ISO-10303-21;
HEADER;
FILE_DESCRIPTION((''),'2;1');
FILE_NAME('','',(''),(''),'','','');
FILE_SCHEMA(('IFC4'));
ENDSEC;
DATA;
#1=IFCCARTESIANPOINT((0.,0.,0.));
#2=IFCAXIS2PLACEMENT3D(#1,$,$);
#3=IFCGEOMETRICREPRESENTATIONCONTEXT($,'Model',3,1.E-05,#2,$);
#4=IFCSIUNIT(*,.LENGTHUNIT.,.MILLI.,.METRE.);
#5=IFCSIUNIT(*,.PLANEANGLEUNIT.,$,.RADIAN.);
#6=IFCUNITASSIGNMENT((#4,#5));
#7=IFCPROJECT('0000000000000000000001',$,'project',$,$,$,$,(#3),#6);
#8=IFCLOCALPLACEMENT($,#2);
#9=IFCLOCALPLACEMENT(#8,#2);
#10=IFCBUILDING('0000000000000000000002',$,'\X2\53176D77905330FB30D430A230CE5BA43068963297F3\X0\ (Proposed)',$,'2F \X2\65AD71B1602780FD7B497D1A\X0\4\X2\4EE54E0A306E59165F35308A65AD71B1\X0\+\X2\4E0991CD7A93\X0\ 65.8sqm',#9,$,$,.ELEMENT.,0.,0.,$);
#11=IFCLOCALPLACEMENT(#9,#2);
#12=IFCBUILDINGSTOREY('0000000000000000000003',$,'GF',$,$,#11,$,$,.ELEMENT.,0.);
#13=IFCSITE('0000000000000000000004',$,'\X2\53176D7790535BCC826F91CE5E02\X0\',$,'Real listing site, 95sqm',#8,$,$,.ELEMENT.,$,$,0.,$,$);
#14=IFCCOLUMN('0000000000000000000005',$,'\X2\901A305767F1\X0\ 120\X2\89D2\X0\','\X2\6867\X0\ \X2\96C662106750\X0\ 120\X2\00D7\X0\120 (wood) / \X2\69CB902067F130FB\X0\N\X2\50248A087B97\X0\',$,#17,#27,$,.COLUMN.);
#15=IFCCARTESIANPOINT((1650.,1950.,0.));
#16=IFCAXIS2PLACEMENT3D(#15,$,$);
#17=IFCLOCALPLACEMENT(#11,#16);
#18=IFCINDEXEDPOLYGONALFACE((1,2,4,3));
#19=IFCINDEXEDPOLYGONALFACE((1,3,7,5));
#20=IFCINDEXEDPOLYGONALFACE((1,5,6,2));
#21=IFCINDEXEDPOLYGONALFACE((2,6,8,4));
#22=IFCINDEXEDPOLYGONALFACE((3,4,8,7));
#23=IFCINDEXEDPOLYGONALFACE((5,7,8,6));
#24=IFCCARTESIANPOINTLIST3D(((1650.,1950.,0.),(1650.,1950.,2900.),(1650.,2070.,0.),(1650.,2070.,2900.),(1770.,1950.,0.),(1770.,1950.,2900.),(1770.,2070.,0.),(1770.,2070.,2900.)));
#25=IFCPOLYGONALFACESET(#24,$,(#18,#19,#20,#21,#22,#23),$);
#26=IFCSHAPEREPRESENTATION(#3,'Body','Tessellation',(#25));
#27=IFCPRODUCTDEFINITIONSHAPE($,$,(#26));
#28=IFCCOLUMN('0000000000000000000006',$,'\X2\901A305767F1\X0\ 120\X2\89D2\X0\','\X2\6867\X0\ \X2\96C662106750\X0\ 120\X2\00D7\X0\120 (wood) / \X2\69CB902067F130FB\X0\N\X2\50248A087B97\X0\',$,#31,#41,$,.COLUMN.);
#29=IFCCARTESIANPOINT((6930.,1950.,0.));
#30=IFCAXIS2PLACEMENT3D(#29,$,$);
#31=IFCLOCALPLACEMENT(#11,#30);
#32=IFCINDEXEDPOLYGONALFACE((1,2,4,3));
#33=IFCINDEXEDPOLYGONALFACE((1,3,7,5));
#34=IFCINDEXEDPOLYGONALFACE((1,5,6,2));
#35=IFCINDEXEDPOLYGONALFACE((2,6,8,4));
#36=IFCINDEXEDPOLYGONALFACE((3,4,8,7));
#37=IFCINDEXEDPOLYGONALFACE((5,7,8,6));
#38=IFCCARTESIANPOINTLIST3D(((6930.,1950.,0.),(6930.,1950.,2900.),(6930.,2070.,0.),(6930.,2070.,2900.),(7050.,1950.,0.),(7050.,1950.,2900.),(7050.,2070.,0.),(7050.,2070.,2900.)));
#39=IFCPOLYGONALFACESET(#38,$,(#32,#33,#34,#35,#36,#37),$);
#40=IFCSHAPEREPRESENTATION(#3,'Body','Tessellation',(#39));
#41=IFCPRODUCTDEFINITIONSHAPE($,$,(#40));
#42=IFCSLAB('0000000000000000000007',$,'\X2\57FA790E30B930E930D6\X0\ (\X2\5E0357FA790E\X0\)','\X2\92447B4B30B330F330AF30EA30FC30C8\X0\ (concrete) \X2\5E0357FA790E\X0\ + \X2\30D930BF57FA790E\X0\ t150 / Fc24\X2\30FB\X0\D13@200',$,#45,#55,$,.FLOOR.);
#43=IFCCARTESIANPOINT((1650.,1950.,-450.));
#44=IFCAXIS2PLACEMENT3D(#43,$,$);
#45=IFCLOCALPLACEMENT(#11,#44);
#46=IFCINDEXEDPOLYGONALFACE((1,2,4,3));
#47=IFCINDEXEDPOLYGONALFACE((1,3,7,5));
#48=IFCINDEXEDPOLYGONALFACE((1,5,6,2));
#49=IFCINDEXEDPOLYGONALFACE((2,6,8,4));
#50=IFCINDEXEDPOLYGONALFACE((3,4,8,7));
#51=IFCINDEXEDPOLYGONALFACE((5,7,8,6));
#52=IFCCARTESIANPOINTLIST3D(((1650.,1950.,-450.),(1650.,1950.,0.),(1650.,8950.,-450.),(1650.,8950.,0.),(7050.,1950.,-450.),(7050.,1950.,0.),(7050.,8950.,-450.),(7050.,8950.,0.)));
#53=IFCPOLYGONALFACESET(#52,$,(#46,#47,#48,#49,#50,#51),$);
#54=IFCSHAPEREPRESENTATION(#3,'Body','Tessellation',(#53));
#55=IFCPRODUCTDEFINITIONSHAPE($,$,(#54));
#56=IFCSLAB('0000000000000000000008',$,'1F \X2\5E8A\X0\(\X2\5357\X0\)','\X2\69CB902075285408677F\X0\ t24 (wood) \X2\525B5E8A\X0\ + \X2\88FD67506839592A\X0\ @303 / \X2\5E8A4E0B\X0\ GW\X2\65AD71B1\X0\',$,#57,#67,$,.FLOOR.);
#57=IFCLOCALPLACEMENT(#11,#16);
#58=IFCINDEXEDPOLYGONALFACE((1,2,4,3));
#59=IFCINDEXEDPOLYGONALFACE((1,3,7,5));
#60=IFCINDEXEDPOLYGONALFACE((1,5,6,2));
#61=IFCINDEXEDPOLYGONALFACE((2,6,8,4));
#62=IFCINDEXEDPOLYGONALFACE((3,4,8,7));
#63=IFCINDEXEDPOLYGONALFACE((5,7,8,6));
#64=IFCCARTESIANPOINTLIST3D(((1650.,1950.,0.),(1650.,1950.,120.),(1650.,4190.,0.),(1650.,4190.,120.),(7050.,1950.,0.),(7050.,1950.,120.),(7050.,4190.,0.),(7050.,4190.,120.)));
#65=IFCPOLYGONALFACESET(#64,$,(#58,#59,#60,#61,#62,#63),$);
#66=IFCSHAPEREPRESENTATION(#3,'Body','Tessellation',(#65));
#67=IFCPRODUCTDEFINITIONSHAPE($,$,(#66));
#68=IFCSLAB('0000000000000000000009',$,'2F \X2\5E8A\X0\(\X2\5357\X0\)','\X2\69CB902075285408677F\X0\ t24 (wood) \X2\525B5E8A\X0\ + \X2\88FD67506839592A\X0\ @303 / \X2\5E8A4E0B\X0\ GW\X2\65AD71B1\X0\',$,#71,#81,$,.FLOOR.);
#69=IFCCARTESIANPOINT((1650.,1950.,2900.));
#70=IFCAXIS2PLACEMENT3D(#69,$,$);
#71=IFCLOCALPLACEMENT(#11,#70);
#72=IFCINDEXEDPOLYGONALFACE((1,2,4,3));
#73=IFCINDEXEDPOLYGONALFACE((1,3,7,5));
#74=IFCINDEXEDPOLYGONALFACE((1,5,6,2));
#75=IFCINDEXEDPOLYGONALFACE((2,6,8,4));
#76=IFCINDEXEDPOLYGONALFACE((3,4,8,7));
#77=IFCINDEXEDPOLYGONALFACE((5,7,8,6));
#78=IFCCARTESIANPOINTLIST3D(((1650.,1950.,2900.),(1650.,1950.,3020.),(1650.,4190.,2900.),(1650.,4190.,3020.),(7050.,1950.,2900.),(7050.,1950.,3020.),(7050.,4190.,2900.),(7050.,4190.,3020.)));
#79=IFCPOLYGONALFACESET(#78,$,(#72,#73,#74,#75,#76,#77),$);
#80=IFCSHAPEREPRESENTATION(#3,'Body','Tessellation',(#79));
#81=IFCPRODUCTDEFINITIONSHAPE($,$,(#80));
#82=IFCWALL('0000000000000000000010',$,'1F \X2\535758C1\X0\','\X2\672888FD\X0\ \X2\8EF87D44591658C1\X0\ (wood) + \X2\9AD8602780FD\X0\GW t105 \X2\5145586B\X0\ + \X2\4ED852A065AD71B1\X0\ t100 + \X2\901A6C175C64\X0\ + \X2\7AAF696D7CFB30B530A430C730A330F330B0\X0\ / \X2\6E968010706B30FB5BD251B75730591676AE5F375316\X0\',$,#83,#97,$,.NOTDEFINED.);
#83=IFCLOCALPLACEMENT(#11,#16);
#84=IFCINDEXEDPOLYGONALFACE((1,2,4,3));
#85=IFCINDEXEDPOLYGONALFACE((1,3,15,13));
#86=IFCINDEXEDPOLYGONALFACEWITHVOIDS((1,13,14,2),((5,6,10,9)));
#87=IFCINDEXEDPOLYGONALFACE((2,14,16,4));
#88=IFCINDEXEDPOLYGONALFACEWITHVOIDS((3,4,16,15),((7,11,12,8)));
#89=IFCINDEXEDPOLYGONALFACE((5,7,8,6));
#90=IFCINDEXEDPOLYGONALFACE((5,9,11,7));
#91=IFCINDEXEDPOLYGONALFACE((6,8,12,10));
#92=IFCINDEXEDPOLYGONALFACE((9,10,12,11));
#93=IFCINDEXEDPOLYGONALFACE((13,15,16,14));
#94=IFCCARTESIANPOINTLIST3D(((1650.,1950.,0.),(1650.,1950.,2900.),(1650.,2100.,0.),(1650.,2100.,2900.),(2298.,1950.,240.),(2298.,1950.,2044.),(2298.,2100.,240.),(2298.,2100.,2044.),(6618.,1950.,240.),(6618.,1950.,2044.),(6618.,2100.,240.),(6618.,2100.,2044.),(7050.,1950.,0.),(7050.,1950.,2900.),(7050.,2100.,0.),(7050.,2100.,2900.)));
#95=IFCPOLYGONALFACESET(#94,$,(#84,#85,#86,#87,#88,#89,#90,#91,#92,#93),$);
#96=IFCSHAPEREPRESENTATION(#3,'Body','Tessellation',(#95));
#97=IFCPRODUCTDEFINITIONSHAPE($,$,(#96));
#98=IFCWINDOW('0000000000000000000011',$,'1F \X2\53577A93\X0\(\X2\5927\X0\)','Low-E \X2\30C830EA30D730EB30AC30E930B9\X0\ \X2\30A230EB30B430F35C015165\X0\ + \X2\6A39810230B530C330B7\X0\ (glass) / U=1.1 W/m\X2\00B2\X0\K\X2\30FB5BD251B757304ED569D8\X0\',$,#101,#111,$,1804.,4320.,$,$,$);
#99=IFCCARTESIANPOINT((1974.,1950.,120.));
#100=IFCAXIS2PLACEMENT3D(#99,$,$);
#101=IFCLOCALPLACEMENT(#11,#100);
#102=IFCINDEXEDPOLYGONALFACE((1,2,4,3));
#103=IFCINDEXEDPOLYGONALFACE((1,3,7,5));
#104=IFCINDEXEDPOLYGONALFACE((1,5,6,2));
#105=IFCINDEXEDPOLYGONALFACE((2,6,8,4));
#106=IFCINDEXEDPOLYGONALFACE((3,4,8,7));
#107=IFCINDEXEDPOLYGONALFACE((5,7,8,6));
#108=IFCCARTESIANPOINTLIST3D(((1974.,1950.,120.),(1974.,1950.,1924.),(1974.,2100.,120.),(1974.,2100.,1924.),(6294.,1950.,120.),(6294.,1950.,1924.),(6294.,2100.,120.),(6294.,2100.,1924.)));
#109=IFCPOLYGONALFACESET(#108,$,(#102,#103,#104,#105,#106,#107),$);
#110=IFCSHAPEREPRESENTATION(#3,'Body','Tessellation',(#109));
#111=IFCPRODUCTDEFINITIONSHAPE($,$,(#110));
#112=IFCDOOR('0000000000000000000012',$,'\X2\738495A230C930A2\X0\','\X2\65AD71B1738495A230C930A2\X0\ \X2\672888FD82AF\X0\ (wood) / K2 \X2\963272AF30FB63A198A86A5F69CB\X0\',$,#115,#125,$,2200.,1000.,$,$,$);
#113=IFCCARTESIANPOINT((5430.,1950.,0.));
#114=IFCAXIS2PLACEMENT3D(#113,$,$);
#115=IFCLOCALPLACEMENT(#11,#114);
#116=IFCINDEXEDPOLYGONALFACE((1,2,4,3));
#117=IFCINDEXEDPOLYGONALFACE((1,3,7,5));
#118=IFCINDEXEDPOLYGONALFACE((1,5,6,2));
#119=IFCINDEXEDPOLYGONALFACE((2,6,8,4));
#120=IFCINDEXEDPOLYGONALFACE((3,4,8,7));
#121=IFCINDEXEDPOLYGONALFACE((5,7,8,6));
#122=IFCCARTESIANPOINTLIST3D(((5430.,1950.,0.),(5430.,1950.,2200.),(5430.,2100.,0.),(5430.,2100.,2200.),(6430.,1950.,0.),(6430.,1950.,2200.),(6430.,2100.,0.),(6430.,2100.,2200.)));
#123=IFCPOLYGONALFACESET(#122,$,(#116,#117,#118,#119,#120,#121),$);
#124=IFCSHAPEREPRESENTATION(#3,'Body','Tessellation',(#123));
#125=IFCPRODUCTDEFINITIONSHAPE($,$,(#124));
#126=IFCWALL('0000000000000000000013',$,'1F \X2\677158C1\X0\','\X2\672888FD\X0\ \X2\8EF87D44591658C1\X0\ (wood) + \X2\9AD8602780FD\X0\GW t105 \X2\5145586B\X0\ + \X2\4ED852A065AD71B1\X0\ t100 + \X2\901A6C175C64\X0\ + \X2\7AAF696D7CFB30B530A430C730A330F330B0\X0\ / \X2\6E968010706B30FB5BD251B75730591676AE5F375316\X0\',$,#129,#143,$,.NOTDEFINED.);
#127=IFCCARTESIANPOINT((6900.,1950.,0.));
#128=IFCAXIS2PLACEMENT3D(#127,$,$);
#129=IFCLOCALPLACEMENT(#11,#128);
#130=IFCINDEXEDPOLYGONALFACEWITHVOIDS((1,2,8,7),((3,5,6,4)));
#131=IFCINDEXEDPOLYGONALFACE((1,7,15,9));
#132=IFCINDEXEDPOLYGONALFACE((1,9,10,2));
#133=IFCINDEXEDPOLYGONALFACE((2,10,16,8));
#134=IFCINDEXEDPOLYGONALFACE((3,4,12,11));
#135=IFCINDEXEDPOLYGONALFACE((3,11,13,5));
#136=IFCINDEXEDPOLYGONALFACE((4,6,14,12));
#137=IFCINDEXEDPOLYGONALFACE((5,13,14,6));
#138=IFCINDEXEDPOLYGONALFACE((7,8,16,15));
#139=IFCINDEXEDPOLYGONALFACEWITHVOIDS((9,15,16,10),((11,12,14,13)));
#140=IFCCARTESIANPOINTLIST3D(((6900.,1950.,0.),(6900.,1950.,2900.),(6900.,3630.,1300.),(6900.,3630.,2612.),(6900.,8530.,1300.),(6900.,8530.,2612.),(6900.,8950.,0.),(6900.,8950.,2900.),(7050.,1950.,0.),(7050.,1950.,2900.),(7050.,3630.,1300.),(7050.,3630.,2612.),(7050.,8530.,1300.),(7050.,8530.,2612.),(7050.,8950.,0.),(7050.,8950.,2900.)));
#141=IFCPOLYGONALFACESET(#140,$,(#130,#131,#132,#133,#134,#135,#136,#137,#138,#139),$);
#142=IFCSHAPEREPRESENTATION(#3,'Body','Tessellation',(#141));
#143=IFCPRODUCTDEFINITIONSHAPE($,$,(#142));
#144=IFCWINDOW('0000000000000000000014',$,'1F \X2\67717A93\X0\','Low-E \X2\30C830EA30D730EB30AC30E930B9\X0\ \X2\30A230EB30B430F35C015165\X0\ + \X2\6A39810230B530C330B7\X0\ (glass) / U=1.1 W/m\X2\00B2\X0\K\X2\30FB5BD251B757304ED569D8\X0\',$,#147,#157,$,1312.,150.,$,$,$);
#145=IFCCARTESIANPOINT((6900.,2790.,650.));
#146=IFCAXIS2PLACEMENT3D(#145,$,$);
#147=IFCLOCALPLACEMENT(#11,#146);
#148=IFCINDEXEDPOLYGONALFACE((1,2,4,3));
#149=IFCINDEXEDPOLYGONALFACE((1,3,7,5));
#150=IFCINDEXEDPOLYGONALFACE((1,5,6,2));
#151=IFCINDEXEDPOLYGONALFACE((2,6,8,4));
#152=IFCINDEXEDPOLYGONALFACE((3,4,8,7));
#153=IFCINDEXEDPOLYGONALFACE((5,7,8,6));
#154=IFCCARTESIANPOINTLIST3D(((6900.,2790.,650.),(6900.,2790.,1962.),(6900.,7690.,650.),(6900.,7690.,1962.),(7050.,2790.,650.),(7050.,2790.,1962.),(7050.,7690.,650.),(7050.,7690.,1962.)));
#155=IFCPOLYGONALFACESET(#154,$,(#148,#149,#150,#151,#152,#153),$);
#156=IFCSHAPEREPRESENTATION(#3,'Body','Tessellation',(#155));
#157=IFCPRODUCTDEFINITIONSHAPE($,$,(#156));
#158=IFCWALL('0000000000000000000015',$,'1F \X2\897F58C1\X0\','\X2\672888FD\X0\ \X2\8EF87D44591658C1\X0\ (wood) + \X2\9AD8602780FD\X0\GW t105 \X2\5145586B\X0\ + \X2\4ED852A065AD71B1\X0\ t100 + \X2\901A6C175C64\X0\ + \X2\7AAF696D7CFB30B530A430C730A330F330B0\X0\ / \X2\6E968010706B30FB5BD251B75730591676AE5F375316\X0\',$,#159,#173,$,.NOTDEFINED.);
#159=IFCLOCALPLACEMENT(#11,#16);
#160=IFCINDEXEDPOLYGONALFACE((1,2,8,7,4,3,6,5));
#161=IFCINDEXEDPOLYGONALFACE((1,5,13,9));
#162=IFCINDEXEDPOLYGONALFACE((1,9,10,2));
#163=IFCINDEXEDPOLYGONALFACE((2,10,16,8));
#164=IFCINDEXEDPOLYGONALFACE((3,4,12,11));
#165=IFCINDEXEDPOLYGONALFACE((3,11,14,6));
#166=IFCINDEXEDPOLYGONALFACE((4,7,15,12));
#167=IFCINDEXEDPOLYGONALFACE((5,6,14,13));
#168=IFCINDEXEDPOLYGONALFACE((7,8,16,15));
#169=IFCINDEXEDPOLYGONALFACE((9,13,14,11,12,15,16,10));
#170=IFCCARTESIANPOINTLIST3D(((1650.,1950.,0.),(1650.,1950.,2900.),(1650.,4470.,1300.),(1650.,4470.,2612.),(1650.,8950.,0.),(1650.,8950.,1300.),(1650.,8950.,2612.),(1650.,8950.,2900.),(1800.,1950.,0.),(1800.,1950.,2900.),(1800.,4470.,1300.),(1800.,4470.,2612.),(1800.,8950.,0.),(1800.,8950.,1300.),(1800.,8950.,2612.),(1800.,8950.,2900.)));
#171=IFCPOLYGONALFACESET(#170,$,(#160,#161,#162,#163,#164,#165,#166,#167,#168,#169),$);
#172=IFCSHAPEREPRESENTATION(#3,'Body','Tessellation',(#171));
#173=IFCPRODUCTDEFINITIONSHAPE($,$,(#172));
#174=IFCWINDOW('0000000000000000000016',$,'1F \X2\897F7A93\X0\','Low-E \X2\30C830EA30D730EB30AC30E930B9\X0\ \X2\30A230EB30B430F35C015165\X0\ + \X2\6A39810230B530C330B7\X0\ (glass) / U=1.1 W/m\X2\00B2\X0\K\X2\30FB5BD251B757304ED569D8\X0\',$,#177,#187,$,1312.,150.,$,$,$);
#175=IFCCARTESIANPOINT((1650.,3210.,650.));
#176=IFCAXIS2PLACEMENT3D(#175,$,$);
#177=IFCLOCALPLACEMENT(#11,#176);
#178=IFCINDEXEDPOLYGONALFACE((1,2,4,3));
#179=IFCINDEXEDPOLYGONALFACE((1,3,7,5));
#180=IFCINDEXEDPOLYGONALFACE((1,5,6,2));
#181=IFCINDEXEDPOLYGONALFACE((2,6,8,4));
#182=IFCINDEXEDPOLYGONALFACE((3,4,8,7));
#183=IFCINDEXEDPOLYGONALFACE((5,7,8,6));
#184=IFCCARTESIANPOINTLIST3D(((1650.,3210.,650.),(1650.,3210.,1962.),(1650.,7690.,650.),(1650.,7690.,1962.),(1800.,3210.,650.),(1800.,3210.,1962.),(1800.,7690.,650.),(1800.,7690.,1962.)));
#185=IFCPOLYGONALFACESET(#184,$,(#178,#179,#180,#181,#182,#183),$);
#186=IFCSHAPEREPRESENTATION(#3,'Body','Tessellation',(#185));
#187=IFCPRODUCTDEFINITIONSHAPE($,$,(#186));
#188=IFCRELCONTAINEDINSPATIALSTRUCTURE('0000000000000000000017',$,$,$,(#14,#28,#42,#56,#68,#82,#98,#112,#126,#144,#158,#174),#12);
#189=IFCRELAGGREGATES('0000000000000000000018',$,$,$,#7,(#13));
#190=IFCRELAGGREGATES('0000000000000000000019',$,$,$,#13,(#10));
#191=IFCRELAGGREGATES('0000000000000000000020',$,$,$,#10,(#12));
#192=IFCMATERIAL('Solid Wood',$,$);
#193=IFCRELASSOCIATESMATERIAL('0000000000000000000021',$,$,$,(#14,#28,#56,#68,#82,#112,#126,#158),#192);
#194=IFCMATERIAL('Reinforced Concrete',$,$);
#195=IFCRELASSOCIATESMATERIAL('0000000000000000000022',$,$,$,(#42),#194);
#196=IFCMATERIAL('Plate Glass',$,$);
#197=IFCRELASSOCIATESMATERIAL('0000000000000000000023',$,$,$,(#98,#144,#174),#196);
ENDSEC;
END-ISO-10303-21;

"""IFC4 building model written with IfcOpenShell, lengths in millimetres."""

from ifc_helpers import new_model, si_unit, frame, frame_2d, origin, place, context, project, spatial, rectangle, extrude, material, element, fill, save


model = new_model("IFC4")

# Units and contexts
model_context = context("Model", 3, precision=1e-05, world=origin())
ifc_project = project(units=[si_unit("LENGTHUNIT", "METRE", prefix="MILLI"), si_unit("PLANEANGLEUNIT", "RADIAN")], contexts=[model_context])

# Site, building, storey
site_placement = place(None, origin())
site = spatial("IfcSite", under=ifc_project, at=site_placement, Name="北海道富良野市", ObjectType="Real listing site, 95sqm", CompositionType="ELEMENT", RefElevation=0.0)
building_placement = place(site_placement, origin())
building = spatial("IfcBuilding", under=site, at=building_placement, Name="北海道・ピアノ室と防音 (Proposed)", ObjectType="2F 断熱性能等級4以上の外張り断熱+三重窓 65.8sqm", CompositionType="ELEMENT", ElevationOfRefHeight=0.0, ElevationOfTerrain=0.0)
storey_placement = place(building_placement, origin())
storey = spatial("IfcBuildingStorey", under=building, at=storey_placement, Name="GF", CompositionType="ELEMENT", Elevation=0.0)

# Columns
ifc_material_1 = material(Name="Solid Wood")
column_1_placement = place(storey_placement, frame((1650.0, 1950.0, 0.0)))
element("IfcColumn", 1, at=column_1_placement, inside=storey, material=ifc_material_1, Name="通し柱 120角", Description="桧 集成材 120×120 (wood) / 構造柱・N値計算", PredefinedType="COLUMN", context=model_context, shape_type="SweptSolid", body=[
    extrude(rectangle(XDim=120.0, YDim=120.0, at=frame_2d((60.0, 60.0))), frame((1650.0, 1950.0, 0.0)), (0.0, 0.0, 1.0), 2900.0),
])
column_2_placement = place(storey_placement, frame((6930.0, 1950.0, 0.0)))
element("IfcColumn", 2, at=column_2_placement, inside=storey, material=ifc_material_1, Name="通し柱 120角", Description="桧 集成材 120×120 (wood) / 構造柱・N値計算", PredefinedType="COLUMN", context=model_context, shape_type="SweptSolid", body=[
    extrude(rectangle(XDim=120.0, YDim=120.0, at=frame_2d((60.0, 60.0))), frame((6930.0, 1950.0, 0.0)), (0.0, 0.0, 1.0), 2900.0),
])

# Slabs
ifc_material_2 = material(Name="Reinforced Concrete")
slab_1_placement = place(storey_placement, frame((1650.0, 1950.0, -450.0)))
element("IfcSlab", 3, at=slab_1_placement, inside=storey, material=ifc_material_2, Name="基礎スラブ (布基礎)", Description="鉄筋コンクリート (concrete) 布基礎 + ベタ基礎 t150 / Fc24・D13@200", PredefinedType="FLOOR", context=model_context, shape_type="SweptSolid", body=[
    extrude(rectangle(XDim=5400.0, YDim=7000.0, at=frame_2d((2700.0, 3500.0))), frame((1650.0, 1950.0, -450.0)), (0.0, 0.0, 1.0), 450.0),
])
slab_2_placement = place(storey_placement, frame((1650.0, 1950.0, 0.0)))
element("IfcSlab", 4, at=slab_2_placement, inside=storey, material=ifc_material_1, Name="1F 床(南)", Description="構造用合板 t24 (wood) 剛床 + 製材根太 @303 / 床下 GW断熱", PredefinedType="FLOOR", context=model_context, shape_type="SweptSolid", body=[
    extrude(rectangle(XDim=5400.0, YDim=2240.0, at=frame_2d((2700.0, 1120.0))), frame((1650.0, 1950.0, 0.0)), (0.0, 0.0, 1.0), 120.0),
])
slab_3_placement = place(storey_placement, frame((1650.0, 1950.0, 2900.0)))
element("IfcSlab", 5, at=slab_3_placement, inside=storey, material=ifc_material_1, Name="2F 床(南)", Description="構造用合板 t24 (wood) 剛床 + 製材根太 @303 / 床下 GW断熱", PredefinedType="FLOOR", context=model_context, shape_type="SweptSolid", body=[
    extrude(rectangle(XDim=5400.0, YDim=2240.0, at=frame_2d((2700.0, 1120.0))), frame((1650.0, 1950.0, 2900.0)), (0.0, 0.0, 1.0), 120.0),
])

# Wall, openings, window, door
wall_1_placement = place(storey_placement, frame((1650.0, 1950.0, 0.0)))
wall_1 = element("IfcWall", 6, at=wall_1_placement, inside=storey, material=ifc_material_1, Name="1F 南壁", Description="木製 軸組外壁 (wood) + 高性能GW t105 充填 + 付加断熱 t100 + 通気層 + 窯業系サイディング / 準耐火・寒冷地外皮強化", PredefinedType="NOTDEFINED", context=model_context, shape_type="SweptSolid", body=[
    extrude(rectangle(XDim=5400.0, YDim=150.0, at=frame_2d((2700.0, 75.0))), frame((1650.0, 1950.0, 0.0)), (0.0, 0.0, 1.0), 2900.0),
])
opening_1_placement = place(storey_placement, frame((1974.0, 1950.0, 120.0)))
opening_1 = element("IfcOpeningElement", 7, at=opening_1_placement, cuts=wall_1, PredefinedType="NOTDEFINED", context=model_context, shape_type="SweptSolid", body=[
    extrude(rectangle(XDim=4320.0, YDim=150.0, at=frame_2d((2160.0, 75.0))), frame((1974.0, 1950.0, 120.0)), (0.0, 0.0, 1.0), 1804.0),
])
opening_2_placement = place(storey_placement, frame((5430.0, 1950.0, 0.0)))
opening_2 = element("IfcOpeningElement", 8, at=opening_2_placement, cuts=wall_1, PredefinedType="NOTDEFINED", context=model_context, shape_type="SweptSolid", body=[
    extrude(rectangle(XDim=1000.0, YDim=150.0, at=frame_2d((500.0, 75.0))), frame((5430.0, 1950.0, 0.0)), (0.0, 0.0, 1.0), 2200.0),
])
ifc_material_3 = material(Name="Plate Glass")
window_1_placement = place(storey_placement, frame((1974.0, 1950.0, 120.0)))
window_1 = element("IfcWindow", 9, at=window_1_placement, inside=storey, material=ifc_material_3, Name="1F 南窓(大)", Description="Low-E トリプルガラス アルゴン封入 + 樹脂サッシ (glass) / U=1.1 W/m²K・寒冷地仕様", OverallHeight=1804.0, OverallWidth=4320.0, context=model_context, shape_type="SweptSolid", body=[
    extrude(rectangle(XDim=4320.0, YDim=150.0, at=frame_2d((2160.0, 75.0))), frame((1974.0, 1950.0, 120.0)), (0.0, 0.0, 1.0), 1804.0),
])
fill(opening_1, window_1)
door_placement = place(storey_placement, frame((5430.0, 1950.0, 0.0)))
door = element("IfcDoor", 10, at=door_placement, inside=storey, material=ifc_material_1, Name="玄関ドア", Description="断熱玄関ドア 木製芯 (wood) / K2 防犯・採風機構", OverallHeight=2200.0, OverallWidth=1000.0, context=model_context, shape_type="SweptSolid", body=[
    extrude(rectangle(XDim=1000.0, YDim=150.0, at=frame_2d((500.0, 75.0))), frame((5430.0, 1950.0, 0.0)), (0.0, 0.0, 1.0), 2200.0),
])
fill(opening_2, door)

# Walls, openings, windows
wall_2_placement = place(storey_placement, frame((6900.0, 1950.0, 0.0)))
wall_2 = element("IfcWall", 11, at=wall_2_placement, inside=storey, material=ifc_material_1, Name="1F 東壁", Description="木製 軸組外壁 (wood) + 高性能GW t105 充填 + 付加断熱 t100 + 通気層 + 窯業系サイディング / 準耐火・寒冷地外皮強化", PredefinedType="NOTDEFINED", context=model_context, shape_type="SweptSolid", body=[
    extrude(rectangle(XDim=150.0, YDim=7000.0, at=frame_2d((75.0, 3500.0))), frame((6900.0, 1950.0, 0.0)), (0.0, 0.0, 1.0), 2900.0),
])
opening_3_placement = place(storey_placement, frame((6900.0, 2790.0, 650.0)))
opening_3 = element("IfcOpeningElement", 12, at=opening_3_placement, cuts=wall_2, PredefinedType="NOTDEFINED", context=model_context, shape_type="SweptSolid", body=[
    extrude(rectangle(XDim=150.0, YDim=4900.0, at=frame_2d((75.0, 2450.0))), frame((6900.0, 2790.0, 650.0)), (0.0, 0.0, 1.0), 1312.0),
])
window_2_placement = place(storey_placement, frame((6900.0, 2790.0, 650.0)))
window_2 = element("IfcWindow", 13, at=window_2_placement, inside=storey, material=ifc_material_3, Name="1F 東窓", Description="Low-E トリプルガラス アルゴン封入 + 樹脂サッシ (glass) / U=1.1 W/m²K・寒冷地仕様", OverallHeight=1312.0, OverallWidth=150.0, context=model_context, shape_type="SweptSolid", body=[
    extrude(rectangle(XDim=150.0, YDim=4900.0, at=frame_2d((75.0, 2450.0))), frame((6900.0, 2790.0, 650.0)), (0.0, 0.0, 1.0), 1312.0),
])
fill(opening_3, window_2)
wall_3_placement = place(storey_placement, frame((1650.0, 1950.0, 0.0)))
wall_3 = element("IfcWall", 14, at=wall_3_placement, inside=storey, material=ifc_material_1, Name="1F 西壁", Description="木製 軸組外壁 (wood) + 高性能GW t105 充填 + 付加断熱 t100 + 通気層 + 窯業系サイディング / 準耐火・寒冷地外皮強化", PredefinedType="NOTDEFINED", context=model_context, shape_type="SweptSolid", body=[
    extrude(rectangle(XDim=150.0, YDim=7000.0, at=frame_2d((75.0, 3500.0))), frame((1650.0, 1950.0, 0.0)), (0.0, 0.0, 1.0), 2900.0),
])
opening_4_placement = place(storey_placement, frame((1650.0, 3210.0, 650.0)))
opening_4 = element("IfcOpeningElement", 15, at=opening_4_placement, cuts=wall_3, PredefinedType="NOTDEFINED", context=model_context, shape_type="SweptSolid", body=[
    extrude(rectangle(XDim=150.0, YDim=4480.0, at=frame_2d((75.0, 2240.0))), frame((1650.0, 3210.0, 650.0)), (0.0, 0.0, 1.0), 1312.0),
])
window_3_placement = place(storey_placement, frame((1650.0, 3210.0, 650.0)))
window_3 = element("IfcWindow", 16, at=window_3_placement, inside=storey, material=ifc_material_3, Name="1F 西窓", Description="Low-E トリプルガラス アルゴン封入 + 樹脂サッシ (glass) / U=1.1 W/m²K・寒冷地仕様", OverallHeight=1312.0, OverallWidth=150.0, context=model_context, shape_type="SweptSolid", body=[
    extrude(rectangle(XDim=150.0, YDim=4480.0, at=frame_2d((75.0, 2240.0))), frame((1650.0, 3210.0, 650.0)), (0.0, 0.0, 1.0), 1312.0),
])
fill(opening_4, window_3)

save(model, "model.ifc")
